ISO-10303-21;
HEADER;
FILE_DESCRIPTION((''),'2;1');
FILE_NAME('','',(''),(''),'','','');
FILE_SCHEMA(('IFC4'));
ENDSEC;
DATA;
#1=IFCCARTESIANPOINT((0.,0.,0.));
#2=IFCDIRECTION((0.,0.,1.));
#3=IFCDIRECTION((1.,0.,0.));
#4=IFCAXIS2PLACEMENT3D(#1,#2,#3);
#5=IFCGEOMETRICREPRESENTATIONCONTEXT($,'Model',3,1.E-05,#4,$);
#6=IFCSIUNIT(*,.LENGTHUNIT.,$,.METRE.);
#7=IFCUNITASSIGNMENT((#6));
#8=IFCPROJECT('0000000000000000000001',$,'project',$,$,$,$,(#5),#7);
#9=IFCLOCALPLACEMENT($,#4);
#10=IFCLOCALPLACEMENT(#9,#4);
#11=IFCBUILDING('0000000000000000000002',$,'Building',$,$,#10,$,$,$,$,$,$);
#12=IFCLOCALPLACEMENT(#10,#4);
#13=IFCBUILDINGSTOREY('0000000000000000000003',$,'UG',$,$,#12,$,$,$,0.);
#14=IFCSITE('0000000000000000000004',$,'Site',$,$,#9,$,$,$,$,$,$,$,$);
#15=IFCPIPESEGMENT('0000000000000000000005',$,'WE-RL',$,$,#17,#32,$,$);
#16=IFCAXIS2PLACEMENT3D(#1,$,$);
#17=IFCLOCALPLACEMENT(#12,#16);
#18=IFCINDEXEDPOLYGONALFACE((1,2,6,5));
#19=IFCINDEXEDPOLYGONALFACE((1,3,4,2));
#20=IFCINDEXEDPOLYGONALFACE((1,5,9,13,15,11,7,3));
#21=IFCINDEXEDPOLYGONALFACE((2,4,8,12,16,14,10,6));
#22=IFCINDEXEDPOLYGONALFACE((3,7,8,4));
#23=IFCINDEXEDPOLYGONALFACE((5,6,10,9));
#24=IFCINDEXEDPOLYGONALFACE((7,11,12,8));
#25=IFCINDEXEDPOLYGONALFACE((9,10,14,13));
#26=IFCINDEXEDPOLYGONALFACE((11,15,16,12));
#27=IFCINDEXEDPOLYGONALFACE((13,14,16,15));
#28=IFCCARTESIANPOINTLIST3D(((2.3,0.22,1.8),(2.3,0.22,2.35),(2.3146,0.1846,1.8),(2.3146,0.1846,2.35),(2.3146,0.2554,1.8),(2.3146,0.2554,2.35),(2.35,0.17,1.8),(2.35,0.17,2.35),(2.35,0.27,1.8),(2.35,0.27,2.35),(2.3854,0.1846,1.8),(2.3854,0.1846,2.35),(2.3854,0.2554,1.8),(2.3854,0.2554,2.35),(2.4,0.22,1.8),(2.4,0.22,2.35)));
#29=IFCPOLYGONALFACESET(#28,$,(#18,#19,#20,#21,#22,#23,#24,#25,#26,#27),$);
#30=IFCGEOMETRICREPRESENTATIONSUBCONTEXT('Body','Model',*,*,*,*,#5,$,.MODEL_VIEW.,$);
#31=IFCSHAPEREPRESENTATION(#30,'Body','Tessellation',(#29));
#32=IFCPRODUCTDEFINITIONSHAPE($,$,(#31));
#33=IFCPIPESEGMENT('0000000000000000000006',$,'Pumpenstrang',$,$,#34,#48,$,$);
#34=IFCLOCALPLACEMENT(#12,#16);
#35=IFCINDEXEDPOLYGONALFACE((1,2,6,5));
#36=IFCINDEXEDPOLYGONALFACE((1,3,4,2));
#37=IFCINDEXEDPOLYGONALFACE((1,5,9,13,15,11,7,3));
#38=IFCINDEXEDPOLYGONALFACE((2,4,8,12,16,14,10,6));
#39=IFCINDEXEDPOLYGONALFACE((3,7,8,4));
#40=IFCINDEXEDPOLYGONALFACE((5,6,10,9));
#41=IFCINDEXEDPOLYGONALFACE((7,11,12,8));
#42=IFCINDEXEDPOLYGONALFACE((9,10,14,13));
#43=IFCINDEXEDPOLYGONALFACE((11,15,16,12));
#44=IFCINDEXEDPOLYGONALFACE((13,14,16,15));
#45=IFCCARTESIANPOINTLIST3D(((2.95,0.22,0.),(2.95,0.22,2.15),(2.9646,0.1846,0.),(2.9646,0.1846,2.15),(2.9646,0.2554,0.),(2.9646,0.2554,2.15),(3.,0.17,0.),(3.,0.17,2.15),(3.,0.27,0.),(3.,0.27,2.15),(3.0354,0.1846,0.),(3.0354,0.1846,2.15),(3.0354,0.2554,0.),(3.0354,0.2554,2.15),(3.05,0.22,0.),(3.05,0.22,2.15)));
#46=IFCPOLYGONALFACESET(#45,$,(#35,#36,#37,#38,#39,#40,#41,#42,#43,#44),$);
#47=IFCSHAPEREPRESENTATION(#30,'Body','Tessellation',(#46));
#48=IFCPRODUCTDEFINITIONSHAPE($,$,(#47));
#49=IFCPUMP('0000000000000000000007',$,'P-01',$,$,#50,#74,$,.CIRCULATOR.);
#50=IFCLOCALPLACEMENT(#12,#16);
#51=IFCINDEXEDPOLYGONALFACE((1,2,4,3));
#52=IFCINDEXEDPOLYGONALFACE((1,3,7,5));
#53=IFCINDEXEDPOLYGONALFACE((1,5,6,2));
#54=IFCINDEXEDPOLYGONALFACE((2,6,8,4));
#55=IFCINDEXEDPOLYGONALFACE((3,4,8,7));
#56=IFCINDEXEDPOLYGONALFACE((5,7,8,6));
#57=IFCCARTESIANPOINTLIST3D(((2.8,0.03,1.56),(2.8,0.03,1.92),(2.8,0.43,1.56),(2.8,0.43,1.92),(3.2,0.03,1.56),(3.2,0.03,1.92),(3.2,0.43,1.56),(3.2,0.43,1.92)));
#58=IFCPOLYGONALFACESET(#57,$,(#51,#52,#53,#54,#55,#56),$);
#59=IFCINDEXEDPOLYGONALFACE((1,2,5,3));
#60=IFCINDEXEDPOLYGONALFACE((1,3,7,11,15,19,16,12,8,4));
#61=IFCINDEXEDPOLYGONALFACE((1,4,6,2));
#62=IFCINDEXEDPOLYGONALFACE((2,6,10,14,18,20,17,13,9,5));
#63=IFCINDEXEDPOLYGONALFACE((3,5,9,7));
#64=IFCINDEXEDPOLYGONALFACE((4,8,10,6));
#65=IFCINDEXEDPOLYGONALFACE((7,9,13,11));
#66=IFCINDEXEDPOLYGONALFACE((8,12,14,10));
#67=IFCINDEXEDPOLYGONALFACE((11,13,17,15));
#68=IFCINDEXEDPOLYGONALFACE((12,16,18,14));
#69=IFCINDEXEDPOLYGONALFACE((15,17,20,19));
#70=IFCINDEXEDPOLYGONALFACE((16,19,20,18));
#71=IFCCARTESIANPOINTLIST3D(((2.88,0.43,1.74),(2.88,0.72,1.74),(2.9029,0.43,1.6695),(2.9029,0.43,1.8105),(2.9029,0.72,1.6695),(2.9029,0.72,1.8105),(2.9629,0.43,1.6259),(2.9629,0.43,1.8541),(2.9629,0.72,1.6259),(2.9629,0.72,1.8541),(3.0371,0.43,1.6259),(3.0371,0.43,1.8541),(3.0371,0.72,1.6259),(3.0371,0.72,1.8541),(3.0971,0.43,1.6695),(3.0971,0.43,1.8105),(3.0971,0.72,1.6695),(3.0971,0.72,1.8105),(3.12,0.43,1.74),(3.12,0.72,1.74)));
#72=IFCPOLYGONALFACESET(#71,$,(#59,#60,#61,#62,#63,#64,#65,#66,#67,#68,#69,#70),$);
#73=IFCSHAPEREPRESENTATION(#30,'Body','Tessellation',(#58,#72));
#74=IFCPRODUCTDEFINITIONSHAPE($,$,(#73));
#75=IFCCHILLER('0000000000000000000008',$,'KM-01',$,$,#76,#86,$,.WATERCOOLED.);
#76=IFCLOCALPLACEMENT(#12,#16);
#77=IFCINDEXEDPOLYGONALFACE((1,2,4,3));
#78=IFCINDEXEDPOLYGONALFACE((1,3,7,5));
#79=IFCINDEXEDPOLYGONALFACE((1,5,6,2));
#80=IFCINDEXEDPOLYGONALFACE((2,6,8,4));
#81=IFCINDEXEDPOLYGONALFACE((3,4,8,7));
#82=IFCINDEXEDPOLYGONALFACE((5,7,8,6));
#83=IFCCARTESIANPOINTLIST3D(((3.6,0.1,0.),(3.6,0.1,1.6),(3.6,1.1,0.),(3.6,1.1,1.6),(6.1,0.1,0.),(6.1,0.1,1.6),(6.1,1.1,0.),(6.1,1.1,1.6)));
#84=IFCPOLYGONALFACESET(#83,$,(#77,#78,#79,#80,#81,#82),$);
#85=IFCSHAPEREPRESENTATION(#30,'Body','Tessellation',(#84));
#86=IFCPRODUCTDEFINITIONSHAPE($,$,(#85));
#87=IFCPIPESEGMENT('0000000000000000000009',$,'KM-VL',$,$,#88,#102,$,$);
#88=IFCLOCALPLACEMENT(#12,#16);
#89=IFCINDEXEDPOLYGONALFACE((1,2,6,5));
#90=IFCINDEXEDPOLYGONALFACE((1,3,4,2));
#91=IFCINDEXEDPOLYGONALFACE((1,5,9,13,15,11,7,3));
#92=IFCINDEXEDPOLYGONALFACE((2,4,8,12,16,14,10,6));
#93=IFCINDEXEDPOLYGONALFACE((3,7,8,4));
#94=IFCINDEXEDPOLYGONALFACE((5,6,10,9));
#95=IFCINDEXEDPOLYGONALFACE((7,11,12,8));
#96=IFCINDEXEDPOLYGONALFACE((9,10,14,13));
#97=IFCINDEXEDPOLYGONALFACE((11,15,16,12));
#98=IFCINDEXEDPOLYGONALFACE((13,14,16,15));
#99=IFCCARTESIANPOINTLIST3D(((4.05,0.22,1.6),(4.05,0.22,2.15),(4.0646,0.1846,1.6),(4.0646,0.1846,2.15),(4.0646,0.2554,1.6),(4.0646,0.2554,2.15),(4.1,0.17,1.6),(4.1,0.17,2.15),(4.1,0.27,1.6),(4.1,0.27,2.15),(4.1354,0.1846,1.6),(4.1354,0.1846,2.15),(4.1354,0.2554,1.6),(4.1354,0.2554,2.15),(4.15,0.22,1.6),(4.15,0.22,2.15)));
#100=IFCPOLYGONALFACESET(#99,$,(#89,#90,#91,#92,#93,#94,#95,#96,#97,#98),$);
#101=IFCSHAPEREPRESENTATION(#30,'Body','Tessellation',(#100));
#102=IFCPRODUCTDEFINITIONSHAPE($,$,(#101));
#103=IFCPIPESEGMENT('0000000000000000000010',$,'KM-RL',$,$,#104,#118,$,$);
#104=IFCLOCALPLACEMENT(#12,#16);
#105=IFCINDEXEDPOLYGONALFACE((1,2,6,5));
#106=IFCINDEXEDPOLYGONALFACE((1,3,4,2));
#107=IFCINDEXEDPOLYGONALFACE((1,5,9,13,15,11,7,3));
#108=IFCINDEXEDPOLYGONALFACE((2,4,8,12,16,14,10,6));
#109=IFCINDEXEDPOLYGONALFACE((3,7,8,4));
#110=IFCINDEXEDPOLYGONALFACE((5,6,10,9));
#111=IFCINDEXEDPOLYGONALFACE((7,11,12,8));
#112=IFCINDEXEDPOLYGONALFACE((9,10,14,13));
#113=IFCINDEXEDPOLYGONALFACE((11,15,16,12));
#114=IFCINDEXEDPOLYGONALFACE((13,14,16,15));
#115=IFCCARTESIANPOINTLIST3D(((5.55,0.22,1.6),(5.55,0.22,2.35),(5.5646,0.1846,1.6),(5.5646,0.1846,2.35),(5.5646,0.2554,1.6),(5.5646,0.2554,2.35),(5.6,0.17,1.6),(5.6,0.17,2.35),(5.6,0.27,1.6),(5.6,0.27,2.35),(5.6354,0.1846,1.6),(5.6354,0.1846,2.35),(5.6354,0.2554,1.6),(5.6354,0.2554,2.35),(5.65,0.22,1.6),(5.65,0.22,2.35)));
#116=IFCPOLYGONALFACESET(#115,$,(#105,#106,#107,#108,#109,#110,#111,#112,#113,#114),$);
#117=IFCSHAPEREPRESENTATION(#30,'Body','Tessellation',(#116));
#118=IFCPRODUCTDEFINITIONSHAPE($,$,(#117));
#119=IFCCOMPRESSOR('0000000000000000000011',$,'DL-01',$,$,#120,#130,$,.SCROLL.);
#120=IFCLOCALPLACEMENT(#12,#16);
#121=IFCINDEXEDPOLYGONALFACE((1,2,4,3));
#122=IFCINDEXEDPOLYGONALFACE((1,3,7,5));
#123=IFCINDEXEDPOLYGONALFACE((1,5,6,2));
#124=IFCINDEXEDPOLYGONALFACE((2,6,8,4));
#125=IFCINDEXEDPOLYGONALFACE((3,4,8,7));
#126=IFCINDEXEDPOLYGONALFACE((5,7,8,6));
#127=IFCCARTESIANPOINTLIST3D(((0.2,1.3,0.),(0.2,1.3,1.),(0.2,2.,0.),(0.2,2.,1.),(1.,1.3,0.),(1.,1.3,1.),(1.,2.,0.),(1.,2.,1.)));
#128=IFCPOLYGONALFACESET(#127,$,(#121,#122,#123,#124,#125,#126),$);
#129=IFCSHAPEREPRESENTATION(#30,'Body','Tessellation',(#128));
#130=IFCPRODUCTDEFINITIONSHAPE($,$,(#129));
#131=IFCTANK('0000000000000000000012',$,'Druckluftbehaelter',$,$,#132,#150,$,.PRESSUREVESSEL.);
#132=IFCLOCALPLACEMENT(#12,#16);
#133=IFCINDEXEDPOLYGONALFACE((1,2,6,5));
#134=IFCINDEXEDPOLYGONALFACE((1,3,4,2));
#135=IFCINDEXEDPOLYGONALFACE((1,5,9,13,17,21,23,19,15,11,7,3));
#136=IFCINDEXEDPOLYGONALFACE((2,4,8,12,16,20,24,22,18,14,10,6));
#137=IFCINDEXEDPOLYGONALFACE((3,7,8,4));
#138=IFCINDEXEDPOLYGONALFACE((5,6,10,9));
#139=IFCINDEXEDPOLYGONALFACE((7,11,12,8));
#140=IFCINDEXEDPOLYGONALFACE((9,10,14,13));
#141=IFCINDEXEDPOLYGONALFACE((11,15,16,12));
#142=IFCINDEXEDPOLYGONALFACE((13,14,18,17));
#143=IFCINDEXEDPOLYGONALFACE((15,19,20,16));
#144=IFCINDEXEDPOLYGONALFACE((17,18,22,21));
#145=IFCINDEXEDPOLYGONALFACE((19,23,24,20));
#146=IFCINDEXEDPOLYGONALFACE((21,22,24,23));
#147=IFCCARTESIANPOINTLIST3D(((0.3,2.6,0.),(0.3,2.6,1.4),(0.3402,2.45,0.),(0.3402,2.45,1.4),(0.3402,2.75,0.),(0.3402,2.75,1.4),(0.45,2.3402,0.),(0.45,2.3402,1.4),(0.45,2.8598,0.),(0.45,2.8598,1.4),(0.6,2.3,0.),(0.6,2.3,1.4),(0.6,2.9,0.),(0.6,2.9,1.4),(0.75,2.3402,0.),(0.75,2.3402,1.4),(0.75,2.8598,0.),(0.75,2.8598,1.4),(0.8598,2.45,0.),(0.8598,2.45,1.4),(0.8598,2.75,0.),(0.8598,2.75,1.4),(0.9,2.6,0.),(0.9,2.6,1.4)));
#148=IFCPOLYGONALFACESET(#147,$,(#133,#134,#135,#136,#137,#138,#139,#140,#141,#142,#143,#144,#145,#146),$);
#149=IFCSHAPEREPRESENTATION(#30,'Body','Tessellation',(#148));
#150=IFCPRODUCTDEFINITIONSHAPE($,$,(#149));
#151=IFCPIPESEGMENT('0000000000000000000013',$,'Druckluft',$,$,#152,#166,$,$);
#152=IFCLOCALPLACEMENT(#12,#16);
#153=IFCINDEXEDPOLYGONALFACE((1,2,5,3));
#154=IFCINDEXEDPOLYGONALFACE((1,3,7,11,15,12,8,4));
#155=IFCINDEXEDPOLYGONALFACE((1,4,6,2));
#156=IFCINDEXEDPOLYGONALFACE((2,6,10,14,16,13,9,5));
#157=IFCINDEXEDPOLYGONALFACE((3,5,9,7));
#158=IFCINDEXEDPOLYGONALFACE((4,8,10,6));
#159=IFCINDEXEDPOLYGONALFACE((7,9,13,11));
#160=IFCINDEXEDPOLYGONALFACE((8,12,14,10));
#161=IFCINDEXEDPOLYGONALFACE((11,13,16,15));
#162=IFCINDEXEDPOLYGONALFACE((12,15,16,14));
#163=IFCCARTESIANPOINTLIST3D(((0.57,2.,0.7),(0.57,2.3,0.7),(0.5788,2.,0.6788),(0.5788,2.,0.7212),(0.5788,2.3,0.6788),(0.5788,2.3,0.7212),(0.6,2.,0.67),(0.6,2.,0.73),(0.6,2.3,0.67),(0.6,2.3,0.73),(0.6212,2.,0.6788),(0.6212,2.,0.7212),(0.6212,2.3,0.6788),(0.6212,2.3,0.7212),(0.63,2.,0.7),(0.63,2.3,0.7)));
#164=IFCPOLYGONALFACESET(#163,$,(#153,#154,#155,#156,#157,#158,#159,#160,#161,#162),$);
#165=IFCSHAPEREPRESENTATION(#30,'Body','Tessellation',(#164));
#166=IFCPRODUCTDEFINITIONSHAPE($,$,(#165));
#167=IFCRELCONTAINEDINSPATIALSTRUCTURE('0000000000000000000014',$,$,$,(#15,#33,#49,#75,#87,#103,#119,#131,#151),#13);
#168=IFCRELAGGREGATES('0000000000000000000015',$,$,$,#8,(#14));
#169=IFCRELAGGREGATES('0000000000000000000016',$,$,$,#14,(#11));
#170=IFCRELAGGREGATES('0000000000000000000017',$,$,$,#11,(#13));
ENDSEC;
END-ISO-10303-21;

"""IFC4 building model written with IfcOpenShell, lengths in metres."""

from ifc_helpers import new_model, si_unit, frame, origin_with_axes, place, context, subcontext, project, spatial, polyline, outline, extrude, element, save


model = new_model("IFC4")

# Units and contexts
model_context = context("Model", 3, precision=1e-05, world=origin_with_axes())
body_context = subcontext(model_context, "Body", "Model", "MODEL_VIEW")
ifc_project = project(units=[si_unit("LENGTHUNIT", "METRE")], contexts=[model_context])

# Site, building, storey
site_placement = place(None, origin_with_axes())
site = spatial("IfcSite", under=ifc_project, at=site_placement, Name="Site")
building_placement = place(site_placement, origin_with_axes())
building = spatial("IfcBuilding", under=site, at=building_placement, Name="Building")
storey_placement = place(building_placement, origin_with_axes())
storey = spatial("IfcBuildingStorey", under=building, at=storey_placement, Name="UG", Elevation=0.0)

# Pipe segments
pipe_segment_1_placement = place(storey_placement, origin_with_axes())
element("IfcPipeSegment", 1, at=pipe_segment_1_placement, inside=storey, Name="WE-RL", context=body_context, shape_type="SweptSolid", body=[
    extrude(outline(polyline([(0.05, 0.0, 0.0), (0.0354, 0.0354, 0.0), (0.0, 0.05, 0.0), (-0.0354, 0.0354, 0.0), (-0.05, 0.0, 0.0), (-0.0354, -0.0354, 0.0), (0.0, -0.05, 0.0), (0.0354, -0.0354, 0.0), (0.05, 0.0, 0.0)])), frame((2.35, 0.22, 1.8), z_axis=(0.0, 0.0, 1.0), x_axis=(1.0, 0.0, 0.0)), (0.0, 0.0, 1.0), 0.55),
])
pipe_segment_2_placement = place(storey_placement, origin_with_axes())
element("IfcPipeSegment", 2, at=pipe_segment_2_placement, inside=storey, Name="Pumpenstrang", context=body_context, shape_type="SweptSolid", body=[
    extrude(outline(polyline([(0.05, 0.0, 0.0), (0.0354, 0.0354, 0.0), (0.0, 0.05, 0.0), (-0.0354, 0.0354, 0.0), (-0.05, 0.0, 0.0), (-0.0354, -0.0354, 0.0), (0.0, -0.05, 0.0), (0.0354, -0.0354, 0.0), (0.05, 0.0, 0.0)])), frame((3.0, 0.22, 0.0), z_axis=(0.0, 0.0, 1.0), x_axis=(1.0, 0.0, 0.0)), (0.0, 0.0, 1.0), 2.15),
])

# Pump
pump_placement = place(storey_placement, origin_with_axes())
element("IfcPump", 3, at=pump_placement, inside=storey, Name="P-01", PredefinedType="CIRCULATOR", context=body_context, shape_type="SweptSolid", body=[
    extrude(outline(polyline([(2.8, 0.03, 0.0), (3.2, 0.03, 0.0), (3.2, 0.43, 0.0), (2.8, 0.43, 0.0), (2.8, 0.03, 0.0)])), frame((0.0, 0.0, 1.56), z_axis=(0.0, 0.0, 1.0), x_axis=(1.0, 0.0, 0.0)), (0.0, 0.0, 1.0), 0.36),
    extrude(outline(polyline([(0.12, 0.0, 0.0), (0.0971, 0.0705, 0.0), (0.0371, 0.1141, 0.0), (-0.0371, 0.1141, 0.0), (-0.0971, 0.0705, 0.0), (-0.12, 0.0, 0.0), (-0.0971, -0.0705, 0.0), (-0.0371, -0.1141, 0.0), (0.0371, -0.1141, 0.0), (0.0971, -0.0705, 0.0), (0.12, 0.0, 0.0)])), frame((3.0, 0.43, 1.74), z_axis=(0.0, 1.0, 0.0), x_axis=(-1.0, 0.0, 0.0)), (0.0, 0.0, 1.0), 0.29),
])

# Chiller
chiller_placement = place(storey_placement, origin_with_axes())
element("IfcChiller", 4, at=chiller_placement, inside=storey, Name="KM-01", PredefinedType="WATERCOOLED", context=body_context, shape_type="SweptSolid", body=[
    extrude(outline(polyline([(3.6, 0.1, 0.0), (6.1, 0.1, 0.0), (6.1, 1.1, 0.0), (3.6, 1.1, 0.0), (3.6, 0.1, 0.0)])), origin_with_axes(), (0.0, 0.0, 1.0), 1.6),
])

# Pipe segments
pipe_segment_3_placement = place(storey_placement, origin_with_axes())
element("IfcPipeSegment", 5, at=pipe_segment_3_placement, inside=storey, Name="KM-VL", context=body_context, shape_type="SweptSolid", body=[
    extrude(outline(polyline([(0.05, 0.0, 0.0), (0.0354, 0.0354, 0.0), (0.0, 0.05, 0.0), (-0.0354, 0.0354, 0.0), (-0.05, 0.0, 0.0), (-0.0354, -0.0354, 0.0), (0.0, -0.05, 0.0), (0.0354, -0.0354, 0.0), (0.05, 0.0, 0.0)])), frame((4.1, 0.22, 1.6), z_axis=(0.0, 0.0, 1.0), x_axis=(1.0, 0.0, 0.0)), (0.0, 0.0, 1.0), 0.55),
])
pipe_segment_4_placement = place(storey_placement, origin_with_axes())
element("IfcPipeSegment", 6, at=pipe_segment_4_placement, inside=storey, Name="KM-RL", context=body_context, shape_type="SweptSolid", body=[
    extrude(outline(polyline([(0.05, 0.0, 0.0), (0.0354, 0.0354, 0.0), (0.0, 0.05, 0.0), (-0.0354, 0.0354, 0.0), (-0.05, 0.0, 0.0), (-0.0354, -0.0354, 0.0), (0.0, -0.05, 0.0), (0.0354, -0.0354, 0.0), (0.05, 0.0, 0.0)])), frame((5.6, 0.22, 1.6), z_axis=(0.0, 0.0, 1.0), x_axis=(1.0, 0.0, 0.0)), (0.0, 0.0, 1.0), 0.75),
])

# Compressor
compressor_placement = place(storey_placement, origin_with_axes())
element("IfcCompressor", 7, at=compressor_placement, inside=storey, Name="DL-01", PredefinedType="SCROLL", context=body_context, shape_type="SweptSolid", body=[
    extrude(outline(polyline([(0.2, 1.3, 0.0), (1.0, 1.3, 0.0), (1.0, 2.0, 0.0), (0.2, 2.0, 0.0), (0.2, 1.3, 0.0)])), origin_with_axes(), (0.0, 0.0, 1.0), 1.0),
])

# Tank
tank_1_placement = place(storey_placement, origin_with_axes())
element("IfcTank", 8, at=tank_1_placement, inside=storey, Name="Druckluftbehaelter", PredefinedType="PRESSUREVESSEL", context=body_context, shape_type="SweptSolid", body=[
    extrude(outline(polyline([(0.3, 0.0, 0.0), (0.2598, 0.15, 0.0), (0.15, 0.2598, 0.0), (0.0, 0.3, 0.0), (-0.15, 0.2598, 0.0), (-0.2598, 0.15, 0.0), (-0.3, 0.0, 0.0), (-0.2598, -0.15, 0.0), (-0.15, -0.2598, 0.0), (0.0, -0.3, 0.0), (0.15, -0.2598, 0.0), (0.2598, -0.15, 0.0), (0.3, 0.0, 0.0)])), frame((0.6, 2.6, 0.0), z_axis=(0.0, 0.0, 1.0), x_axis=(1.0, 0.0, 0.0)), (0.0, 0.0, 1.0), 1.4),
])

# Pipe segment
pipe_segment_5_placement = place(storey_placement, origin_with_axes())
element("IfcPipeSegment", 9, at=pipe_segment_5_placement, inside=storey, Name="Druckluft", context=body_context, shape_type="SweptSolid", body=[
    extrude(outline(polyline([(0.03, 0.0, 0.0), (0.0212, 0.0212, 0.0), (0.0, 0.03, 0.0), (-0.0212, 0.0212, 0.0), (-0.03, 0.0, 0.0), (-0.0212, -0.0212, 0.0), (0.0, -0.03, 0.0), (0.0212, -0.0212, 0.0), (0.03, 0.0, 0.0)])), frame((0.6, 2.0, 0.7), z_axis=(0.0, 1.0, 0.0), x_axis=(-1.0, 0.0, 0.0)), (0.0, 0.0, 1.0), 0.3),
])

save(model, "model.ifc")
